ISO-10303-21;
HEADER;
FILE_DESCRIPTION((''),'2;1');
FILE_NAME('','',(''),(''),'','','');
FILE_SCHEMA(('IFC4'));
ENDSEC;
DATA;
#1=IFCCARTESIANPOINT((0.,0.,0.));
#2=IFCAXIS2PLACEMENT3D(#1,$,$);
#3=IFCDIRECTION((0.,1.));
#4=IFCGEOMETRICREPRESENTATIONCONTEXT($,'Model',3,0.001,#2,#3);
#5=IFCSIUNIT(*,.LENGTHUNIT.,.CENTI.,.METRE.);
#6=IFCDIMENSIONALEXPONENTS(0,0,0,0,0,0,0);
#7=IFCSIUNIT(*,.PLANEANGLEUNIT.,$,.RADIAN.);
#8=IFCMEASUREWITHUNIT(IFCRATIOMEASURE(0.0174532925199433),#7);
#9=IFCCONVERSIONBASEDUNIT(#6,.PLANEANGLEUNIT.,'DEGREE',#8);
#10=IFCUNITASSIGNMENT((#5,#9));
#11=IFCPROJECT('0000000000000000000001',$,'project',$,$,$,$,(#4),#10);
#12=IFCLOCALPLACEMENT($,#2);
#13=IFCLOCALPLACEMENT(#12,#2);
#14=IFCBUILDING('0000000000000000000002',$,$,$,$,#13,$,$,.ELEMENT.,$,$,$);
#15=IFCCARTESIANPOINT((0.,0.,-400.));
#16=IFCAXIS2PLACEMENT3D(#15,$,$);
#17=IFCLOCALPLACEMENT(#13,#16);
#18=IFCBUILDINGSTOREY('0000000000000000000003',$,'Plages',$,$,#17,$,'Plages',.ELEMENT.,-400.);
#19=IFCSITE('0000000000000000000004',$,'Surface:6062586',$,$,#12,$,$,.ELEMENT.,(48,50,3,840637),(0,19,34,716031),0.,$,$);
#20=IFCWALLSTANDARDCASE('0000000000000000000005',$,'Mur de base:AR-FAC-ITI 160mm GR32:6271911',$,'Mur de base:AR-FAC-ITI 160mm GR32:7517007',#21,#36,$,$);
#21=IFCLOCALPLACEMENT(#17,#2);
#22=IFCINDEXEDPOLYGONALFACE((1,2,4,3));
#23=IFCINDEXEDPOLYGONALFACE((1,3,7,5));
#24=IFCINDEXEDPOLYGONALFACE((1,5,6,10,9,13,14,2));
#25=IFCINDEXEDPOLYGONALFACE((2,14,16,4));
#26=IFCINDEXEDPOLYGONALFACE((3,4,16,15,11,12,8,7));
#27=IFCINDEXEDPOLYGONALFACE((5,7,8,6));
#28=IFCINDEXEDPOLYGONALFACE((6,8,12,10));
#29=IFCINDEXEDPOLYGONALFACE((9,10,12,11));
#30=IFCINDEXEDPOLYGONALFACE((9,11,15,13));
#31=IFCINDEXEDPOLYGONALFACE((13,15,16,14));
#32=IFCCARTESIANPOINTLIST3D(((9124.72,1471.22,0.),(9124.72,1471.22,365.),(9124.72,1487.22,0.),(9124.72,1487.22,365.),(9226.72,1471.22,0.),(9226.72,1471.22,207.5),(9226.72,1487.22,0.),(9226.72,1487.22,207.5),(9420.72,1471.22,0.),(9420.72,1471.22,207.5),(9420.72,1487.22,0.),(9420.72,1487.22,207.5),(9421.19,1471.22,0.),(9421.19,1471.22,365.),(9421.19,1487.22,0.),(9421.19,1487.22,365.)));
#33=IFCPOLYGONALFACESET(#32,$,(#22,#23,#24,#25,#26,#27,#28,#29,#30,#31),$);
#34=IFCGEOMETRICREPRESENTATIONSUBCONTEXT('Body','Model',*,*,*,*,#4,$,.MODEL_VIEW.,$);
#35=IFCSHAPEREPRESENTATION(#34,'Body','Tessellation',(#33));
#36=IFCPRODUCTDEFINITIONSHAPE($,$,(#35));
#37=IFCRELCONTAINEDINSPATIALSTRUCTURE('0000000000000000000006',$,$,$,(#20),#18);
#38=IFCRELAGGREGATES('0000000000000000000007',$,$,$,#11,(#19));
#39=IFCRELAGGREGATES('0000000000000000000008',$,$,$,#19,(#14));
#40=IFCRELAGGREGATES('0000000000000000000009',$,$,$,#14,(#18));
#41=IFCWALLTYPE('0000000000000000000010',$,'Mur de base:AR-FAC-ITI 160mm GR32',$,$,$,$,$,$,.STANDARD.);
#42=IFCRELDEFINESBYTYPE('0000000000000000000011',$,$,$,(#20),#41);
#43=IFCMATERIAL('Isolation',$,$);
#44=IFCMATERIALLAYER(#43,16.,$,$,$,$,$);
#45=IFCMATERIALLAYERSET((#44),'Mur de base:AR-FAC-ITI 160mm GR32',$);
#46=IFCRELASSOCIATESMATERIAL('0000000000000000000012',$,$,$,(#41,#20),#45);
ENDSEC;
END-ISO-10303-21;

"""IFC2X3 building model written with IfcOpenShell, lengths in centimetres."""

from ifc_helpers import new_model, entity, si_unit, converted_unit, direction, frame, frame_2d, origin, place, context, subcontext, project, spatial, rectangle, extrude, material, layer, layer_set, layer_usage, type_object, element, save


model = new_model("IFC2X3")

# Units and contexts
model_context = context("Model", 3, precision=0.001, world=origin(), true_north=direction((0.0, 1.0)))
body_context = subcontext(model_context, "Body", "Model", "MODEL_VIEW")
ifc_project = project(units=[si_unit("LENGTHUNIT", "METRE", prefix="CENTI"), converted_unit("PLANEANGLEUNIT", "DEGREE", entity("IfcRatioMeasure", 0.0174532925199433), si_unit("PLANEANGLEUNIT", "RADIAN"), dimensions=[0, 0, 0, 0, 0, 0, 0])], contexts=[model_context])

# Site, building, storey
site_placement = place(None, origin())
site = spatial("IfcSite", under=ifc_project, at=site_placement, Name="Surface:6062586", CompositionType="ELEMENT", RefLatitude=(48, 50, 3, 840637), RefLongitude=(0, 19, 34, 716031), RefElevation=0.0)
building_placement = place(site_placement, origin())
building = spatial("IfcBuilding", under=site, at=building_placement, CompositionType="ELEMENT")
storey_placement = place(building_placement, frame((0.0, 0.0, -400.0)))
storey = spatial("IfcBuildingStorey", under=building, at=storey_placement, Name="Plages", LongName="Plages", CompositionType="ELEMENT", Elevation=-400.0)

# Shared definitions
ifc_material_1 = material(Name="Isolation")

# Wall, opening
ifc_layer_1 = layer(ifc_material_1, 16.0)
ifc_layer_set_1 = layer_set([ifc_layer_1], Name="Mur de base:AR-FAC-ITI 160mm GR32")
ifc_layer_usage_1 = layer_usage(ifc_layer_set_1, "AXIS2", "NEGATIVE", 8.0)
wall_type_1 = type_object("IfcWallType", Name="Mur de base:AR-FAC-ITI 160mm GR32", PredefinedType="STANDARD", material=ifc_layer_set_1)
wall_1_placement = place(storey_placement, frame((9421.19, 1479.22, 0.0), z_axis=(0.0, 0.0, 1.0), x_axis=(-1.0, 0.0, 0.0)))
wall_1 = element("IfcWallStandardCase", 1, at=wall_1_placement, inside=storey, type_object=wall_type_1, material=ifc_layer_usage_1, Name="Mur de base:AR-FAC-ITI 160mm GR32:6271911", ObjectType="Mur de base:AR-FAC-ITI 160mm GR32:7517007", context=body_context, shape_type="SweptSolid", body=[
    extrude(rectangle(XDim=296.47, YDim=16.0, at=frame_2d((148.23, 0.0), x_axis=(-1.0, 0.0))), origin(), (0.0, 0.0, 1.0), 365.0),
])
opening_1_placement = place(wall_1_placement, frame((194.47, 180.4, 0.0)))
element("IfcOpeningElement", 2, at=opening_1_placement, cuts=wall_1, ObjectType="Opening", context=body_context, shape_type="SweptSolid", body=[
    extrude(rectangle(XDim=207.5, YDim=194.0, at=frame_2d((0.0, 0.0), x_axis=(1.0, 0.0))), frame((-97.0, -304.8, 103.75), z_axis=(0.0, 1.0, 0.0), x_axis=(0.0, 0.0, 1.0)), (0.0, 0.0, 1.0), 304.8),
])

save(model, "model.ifc")
